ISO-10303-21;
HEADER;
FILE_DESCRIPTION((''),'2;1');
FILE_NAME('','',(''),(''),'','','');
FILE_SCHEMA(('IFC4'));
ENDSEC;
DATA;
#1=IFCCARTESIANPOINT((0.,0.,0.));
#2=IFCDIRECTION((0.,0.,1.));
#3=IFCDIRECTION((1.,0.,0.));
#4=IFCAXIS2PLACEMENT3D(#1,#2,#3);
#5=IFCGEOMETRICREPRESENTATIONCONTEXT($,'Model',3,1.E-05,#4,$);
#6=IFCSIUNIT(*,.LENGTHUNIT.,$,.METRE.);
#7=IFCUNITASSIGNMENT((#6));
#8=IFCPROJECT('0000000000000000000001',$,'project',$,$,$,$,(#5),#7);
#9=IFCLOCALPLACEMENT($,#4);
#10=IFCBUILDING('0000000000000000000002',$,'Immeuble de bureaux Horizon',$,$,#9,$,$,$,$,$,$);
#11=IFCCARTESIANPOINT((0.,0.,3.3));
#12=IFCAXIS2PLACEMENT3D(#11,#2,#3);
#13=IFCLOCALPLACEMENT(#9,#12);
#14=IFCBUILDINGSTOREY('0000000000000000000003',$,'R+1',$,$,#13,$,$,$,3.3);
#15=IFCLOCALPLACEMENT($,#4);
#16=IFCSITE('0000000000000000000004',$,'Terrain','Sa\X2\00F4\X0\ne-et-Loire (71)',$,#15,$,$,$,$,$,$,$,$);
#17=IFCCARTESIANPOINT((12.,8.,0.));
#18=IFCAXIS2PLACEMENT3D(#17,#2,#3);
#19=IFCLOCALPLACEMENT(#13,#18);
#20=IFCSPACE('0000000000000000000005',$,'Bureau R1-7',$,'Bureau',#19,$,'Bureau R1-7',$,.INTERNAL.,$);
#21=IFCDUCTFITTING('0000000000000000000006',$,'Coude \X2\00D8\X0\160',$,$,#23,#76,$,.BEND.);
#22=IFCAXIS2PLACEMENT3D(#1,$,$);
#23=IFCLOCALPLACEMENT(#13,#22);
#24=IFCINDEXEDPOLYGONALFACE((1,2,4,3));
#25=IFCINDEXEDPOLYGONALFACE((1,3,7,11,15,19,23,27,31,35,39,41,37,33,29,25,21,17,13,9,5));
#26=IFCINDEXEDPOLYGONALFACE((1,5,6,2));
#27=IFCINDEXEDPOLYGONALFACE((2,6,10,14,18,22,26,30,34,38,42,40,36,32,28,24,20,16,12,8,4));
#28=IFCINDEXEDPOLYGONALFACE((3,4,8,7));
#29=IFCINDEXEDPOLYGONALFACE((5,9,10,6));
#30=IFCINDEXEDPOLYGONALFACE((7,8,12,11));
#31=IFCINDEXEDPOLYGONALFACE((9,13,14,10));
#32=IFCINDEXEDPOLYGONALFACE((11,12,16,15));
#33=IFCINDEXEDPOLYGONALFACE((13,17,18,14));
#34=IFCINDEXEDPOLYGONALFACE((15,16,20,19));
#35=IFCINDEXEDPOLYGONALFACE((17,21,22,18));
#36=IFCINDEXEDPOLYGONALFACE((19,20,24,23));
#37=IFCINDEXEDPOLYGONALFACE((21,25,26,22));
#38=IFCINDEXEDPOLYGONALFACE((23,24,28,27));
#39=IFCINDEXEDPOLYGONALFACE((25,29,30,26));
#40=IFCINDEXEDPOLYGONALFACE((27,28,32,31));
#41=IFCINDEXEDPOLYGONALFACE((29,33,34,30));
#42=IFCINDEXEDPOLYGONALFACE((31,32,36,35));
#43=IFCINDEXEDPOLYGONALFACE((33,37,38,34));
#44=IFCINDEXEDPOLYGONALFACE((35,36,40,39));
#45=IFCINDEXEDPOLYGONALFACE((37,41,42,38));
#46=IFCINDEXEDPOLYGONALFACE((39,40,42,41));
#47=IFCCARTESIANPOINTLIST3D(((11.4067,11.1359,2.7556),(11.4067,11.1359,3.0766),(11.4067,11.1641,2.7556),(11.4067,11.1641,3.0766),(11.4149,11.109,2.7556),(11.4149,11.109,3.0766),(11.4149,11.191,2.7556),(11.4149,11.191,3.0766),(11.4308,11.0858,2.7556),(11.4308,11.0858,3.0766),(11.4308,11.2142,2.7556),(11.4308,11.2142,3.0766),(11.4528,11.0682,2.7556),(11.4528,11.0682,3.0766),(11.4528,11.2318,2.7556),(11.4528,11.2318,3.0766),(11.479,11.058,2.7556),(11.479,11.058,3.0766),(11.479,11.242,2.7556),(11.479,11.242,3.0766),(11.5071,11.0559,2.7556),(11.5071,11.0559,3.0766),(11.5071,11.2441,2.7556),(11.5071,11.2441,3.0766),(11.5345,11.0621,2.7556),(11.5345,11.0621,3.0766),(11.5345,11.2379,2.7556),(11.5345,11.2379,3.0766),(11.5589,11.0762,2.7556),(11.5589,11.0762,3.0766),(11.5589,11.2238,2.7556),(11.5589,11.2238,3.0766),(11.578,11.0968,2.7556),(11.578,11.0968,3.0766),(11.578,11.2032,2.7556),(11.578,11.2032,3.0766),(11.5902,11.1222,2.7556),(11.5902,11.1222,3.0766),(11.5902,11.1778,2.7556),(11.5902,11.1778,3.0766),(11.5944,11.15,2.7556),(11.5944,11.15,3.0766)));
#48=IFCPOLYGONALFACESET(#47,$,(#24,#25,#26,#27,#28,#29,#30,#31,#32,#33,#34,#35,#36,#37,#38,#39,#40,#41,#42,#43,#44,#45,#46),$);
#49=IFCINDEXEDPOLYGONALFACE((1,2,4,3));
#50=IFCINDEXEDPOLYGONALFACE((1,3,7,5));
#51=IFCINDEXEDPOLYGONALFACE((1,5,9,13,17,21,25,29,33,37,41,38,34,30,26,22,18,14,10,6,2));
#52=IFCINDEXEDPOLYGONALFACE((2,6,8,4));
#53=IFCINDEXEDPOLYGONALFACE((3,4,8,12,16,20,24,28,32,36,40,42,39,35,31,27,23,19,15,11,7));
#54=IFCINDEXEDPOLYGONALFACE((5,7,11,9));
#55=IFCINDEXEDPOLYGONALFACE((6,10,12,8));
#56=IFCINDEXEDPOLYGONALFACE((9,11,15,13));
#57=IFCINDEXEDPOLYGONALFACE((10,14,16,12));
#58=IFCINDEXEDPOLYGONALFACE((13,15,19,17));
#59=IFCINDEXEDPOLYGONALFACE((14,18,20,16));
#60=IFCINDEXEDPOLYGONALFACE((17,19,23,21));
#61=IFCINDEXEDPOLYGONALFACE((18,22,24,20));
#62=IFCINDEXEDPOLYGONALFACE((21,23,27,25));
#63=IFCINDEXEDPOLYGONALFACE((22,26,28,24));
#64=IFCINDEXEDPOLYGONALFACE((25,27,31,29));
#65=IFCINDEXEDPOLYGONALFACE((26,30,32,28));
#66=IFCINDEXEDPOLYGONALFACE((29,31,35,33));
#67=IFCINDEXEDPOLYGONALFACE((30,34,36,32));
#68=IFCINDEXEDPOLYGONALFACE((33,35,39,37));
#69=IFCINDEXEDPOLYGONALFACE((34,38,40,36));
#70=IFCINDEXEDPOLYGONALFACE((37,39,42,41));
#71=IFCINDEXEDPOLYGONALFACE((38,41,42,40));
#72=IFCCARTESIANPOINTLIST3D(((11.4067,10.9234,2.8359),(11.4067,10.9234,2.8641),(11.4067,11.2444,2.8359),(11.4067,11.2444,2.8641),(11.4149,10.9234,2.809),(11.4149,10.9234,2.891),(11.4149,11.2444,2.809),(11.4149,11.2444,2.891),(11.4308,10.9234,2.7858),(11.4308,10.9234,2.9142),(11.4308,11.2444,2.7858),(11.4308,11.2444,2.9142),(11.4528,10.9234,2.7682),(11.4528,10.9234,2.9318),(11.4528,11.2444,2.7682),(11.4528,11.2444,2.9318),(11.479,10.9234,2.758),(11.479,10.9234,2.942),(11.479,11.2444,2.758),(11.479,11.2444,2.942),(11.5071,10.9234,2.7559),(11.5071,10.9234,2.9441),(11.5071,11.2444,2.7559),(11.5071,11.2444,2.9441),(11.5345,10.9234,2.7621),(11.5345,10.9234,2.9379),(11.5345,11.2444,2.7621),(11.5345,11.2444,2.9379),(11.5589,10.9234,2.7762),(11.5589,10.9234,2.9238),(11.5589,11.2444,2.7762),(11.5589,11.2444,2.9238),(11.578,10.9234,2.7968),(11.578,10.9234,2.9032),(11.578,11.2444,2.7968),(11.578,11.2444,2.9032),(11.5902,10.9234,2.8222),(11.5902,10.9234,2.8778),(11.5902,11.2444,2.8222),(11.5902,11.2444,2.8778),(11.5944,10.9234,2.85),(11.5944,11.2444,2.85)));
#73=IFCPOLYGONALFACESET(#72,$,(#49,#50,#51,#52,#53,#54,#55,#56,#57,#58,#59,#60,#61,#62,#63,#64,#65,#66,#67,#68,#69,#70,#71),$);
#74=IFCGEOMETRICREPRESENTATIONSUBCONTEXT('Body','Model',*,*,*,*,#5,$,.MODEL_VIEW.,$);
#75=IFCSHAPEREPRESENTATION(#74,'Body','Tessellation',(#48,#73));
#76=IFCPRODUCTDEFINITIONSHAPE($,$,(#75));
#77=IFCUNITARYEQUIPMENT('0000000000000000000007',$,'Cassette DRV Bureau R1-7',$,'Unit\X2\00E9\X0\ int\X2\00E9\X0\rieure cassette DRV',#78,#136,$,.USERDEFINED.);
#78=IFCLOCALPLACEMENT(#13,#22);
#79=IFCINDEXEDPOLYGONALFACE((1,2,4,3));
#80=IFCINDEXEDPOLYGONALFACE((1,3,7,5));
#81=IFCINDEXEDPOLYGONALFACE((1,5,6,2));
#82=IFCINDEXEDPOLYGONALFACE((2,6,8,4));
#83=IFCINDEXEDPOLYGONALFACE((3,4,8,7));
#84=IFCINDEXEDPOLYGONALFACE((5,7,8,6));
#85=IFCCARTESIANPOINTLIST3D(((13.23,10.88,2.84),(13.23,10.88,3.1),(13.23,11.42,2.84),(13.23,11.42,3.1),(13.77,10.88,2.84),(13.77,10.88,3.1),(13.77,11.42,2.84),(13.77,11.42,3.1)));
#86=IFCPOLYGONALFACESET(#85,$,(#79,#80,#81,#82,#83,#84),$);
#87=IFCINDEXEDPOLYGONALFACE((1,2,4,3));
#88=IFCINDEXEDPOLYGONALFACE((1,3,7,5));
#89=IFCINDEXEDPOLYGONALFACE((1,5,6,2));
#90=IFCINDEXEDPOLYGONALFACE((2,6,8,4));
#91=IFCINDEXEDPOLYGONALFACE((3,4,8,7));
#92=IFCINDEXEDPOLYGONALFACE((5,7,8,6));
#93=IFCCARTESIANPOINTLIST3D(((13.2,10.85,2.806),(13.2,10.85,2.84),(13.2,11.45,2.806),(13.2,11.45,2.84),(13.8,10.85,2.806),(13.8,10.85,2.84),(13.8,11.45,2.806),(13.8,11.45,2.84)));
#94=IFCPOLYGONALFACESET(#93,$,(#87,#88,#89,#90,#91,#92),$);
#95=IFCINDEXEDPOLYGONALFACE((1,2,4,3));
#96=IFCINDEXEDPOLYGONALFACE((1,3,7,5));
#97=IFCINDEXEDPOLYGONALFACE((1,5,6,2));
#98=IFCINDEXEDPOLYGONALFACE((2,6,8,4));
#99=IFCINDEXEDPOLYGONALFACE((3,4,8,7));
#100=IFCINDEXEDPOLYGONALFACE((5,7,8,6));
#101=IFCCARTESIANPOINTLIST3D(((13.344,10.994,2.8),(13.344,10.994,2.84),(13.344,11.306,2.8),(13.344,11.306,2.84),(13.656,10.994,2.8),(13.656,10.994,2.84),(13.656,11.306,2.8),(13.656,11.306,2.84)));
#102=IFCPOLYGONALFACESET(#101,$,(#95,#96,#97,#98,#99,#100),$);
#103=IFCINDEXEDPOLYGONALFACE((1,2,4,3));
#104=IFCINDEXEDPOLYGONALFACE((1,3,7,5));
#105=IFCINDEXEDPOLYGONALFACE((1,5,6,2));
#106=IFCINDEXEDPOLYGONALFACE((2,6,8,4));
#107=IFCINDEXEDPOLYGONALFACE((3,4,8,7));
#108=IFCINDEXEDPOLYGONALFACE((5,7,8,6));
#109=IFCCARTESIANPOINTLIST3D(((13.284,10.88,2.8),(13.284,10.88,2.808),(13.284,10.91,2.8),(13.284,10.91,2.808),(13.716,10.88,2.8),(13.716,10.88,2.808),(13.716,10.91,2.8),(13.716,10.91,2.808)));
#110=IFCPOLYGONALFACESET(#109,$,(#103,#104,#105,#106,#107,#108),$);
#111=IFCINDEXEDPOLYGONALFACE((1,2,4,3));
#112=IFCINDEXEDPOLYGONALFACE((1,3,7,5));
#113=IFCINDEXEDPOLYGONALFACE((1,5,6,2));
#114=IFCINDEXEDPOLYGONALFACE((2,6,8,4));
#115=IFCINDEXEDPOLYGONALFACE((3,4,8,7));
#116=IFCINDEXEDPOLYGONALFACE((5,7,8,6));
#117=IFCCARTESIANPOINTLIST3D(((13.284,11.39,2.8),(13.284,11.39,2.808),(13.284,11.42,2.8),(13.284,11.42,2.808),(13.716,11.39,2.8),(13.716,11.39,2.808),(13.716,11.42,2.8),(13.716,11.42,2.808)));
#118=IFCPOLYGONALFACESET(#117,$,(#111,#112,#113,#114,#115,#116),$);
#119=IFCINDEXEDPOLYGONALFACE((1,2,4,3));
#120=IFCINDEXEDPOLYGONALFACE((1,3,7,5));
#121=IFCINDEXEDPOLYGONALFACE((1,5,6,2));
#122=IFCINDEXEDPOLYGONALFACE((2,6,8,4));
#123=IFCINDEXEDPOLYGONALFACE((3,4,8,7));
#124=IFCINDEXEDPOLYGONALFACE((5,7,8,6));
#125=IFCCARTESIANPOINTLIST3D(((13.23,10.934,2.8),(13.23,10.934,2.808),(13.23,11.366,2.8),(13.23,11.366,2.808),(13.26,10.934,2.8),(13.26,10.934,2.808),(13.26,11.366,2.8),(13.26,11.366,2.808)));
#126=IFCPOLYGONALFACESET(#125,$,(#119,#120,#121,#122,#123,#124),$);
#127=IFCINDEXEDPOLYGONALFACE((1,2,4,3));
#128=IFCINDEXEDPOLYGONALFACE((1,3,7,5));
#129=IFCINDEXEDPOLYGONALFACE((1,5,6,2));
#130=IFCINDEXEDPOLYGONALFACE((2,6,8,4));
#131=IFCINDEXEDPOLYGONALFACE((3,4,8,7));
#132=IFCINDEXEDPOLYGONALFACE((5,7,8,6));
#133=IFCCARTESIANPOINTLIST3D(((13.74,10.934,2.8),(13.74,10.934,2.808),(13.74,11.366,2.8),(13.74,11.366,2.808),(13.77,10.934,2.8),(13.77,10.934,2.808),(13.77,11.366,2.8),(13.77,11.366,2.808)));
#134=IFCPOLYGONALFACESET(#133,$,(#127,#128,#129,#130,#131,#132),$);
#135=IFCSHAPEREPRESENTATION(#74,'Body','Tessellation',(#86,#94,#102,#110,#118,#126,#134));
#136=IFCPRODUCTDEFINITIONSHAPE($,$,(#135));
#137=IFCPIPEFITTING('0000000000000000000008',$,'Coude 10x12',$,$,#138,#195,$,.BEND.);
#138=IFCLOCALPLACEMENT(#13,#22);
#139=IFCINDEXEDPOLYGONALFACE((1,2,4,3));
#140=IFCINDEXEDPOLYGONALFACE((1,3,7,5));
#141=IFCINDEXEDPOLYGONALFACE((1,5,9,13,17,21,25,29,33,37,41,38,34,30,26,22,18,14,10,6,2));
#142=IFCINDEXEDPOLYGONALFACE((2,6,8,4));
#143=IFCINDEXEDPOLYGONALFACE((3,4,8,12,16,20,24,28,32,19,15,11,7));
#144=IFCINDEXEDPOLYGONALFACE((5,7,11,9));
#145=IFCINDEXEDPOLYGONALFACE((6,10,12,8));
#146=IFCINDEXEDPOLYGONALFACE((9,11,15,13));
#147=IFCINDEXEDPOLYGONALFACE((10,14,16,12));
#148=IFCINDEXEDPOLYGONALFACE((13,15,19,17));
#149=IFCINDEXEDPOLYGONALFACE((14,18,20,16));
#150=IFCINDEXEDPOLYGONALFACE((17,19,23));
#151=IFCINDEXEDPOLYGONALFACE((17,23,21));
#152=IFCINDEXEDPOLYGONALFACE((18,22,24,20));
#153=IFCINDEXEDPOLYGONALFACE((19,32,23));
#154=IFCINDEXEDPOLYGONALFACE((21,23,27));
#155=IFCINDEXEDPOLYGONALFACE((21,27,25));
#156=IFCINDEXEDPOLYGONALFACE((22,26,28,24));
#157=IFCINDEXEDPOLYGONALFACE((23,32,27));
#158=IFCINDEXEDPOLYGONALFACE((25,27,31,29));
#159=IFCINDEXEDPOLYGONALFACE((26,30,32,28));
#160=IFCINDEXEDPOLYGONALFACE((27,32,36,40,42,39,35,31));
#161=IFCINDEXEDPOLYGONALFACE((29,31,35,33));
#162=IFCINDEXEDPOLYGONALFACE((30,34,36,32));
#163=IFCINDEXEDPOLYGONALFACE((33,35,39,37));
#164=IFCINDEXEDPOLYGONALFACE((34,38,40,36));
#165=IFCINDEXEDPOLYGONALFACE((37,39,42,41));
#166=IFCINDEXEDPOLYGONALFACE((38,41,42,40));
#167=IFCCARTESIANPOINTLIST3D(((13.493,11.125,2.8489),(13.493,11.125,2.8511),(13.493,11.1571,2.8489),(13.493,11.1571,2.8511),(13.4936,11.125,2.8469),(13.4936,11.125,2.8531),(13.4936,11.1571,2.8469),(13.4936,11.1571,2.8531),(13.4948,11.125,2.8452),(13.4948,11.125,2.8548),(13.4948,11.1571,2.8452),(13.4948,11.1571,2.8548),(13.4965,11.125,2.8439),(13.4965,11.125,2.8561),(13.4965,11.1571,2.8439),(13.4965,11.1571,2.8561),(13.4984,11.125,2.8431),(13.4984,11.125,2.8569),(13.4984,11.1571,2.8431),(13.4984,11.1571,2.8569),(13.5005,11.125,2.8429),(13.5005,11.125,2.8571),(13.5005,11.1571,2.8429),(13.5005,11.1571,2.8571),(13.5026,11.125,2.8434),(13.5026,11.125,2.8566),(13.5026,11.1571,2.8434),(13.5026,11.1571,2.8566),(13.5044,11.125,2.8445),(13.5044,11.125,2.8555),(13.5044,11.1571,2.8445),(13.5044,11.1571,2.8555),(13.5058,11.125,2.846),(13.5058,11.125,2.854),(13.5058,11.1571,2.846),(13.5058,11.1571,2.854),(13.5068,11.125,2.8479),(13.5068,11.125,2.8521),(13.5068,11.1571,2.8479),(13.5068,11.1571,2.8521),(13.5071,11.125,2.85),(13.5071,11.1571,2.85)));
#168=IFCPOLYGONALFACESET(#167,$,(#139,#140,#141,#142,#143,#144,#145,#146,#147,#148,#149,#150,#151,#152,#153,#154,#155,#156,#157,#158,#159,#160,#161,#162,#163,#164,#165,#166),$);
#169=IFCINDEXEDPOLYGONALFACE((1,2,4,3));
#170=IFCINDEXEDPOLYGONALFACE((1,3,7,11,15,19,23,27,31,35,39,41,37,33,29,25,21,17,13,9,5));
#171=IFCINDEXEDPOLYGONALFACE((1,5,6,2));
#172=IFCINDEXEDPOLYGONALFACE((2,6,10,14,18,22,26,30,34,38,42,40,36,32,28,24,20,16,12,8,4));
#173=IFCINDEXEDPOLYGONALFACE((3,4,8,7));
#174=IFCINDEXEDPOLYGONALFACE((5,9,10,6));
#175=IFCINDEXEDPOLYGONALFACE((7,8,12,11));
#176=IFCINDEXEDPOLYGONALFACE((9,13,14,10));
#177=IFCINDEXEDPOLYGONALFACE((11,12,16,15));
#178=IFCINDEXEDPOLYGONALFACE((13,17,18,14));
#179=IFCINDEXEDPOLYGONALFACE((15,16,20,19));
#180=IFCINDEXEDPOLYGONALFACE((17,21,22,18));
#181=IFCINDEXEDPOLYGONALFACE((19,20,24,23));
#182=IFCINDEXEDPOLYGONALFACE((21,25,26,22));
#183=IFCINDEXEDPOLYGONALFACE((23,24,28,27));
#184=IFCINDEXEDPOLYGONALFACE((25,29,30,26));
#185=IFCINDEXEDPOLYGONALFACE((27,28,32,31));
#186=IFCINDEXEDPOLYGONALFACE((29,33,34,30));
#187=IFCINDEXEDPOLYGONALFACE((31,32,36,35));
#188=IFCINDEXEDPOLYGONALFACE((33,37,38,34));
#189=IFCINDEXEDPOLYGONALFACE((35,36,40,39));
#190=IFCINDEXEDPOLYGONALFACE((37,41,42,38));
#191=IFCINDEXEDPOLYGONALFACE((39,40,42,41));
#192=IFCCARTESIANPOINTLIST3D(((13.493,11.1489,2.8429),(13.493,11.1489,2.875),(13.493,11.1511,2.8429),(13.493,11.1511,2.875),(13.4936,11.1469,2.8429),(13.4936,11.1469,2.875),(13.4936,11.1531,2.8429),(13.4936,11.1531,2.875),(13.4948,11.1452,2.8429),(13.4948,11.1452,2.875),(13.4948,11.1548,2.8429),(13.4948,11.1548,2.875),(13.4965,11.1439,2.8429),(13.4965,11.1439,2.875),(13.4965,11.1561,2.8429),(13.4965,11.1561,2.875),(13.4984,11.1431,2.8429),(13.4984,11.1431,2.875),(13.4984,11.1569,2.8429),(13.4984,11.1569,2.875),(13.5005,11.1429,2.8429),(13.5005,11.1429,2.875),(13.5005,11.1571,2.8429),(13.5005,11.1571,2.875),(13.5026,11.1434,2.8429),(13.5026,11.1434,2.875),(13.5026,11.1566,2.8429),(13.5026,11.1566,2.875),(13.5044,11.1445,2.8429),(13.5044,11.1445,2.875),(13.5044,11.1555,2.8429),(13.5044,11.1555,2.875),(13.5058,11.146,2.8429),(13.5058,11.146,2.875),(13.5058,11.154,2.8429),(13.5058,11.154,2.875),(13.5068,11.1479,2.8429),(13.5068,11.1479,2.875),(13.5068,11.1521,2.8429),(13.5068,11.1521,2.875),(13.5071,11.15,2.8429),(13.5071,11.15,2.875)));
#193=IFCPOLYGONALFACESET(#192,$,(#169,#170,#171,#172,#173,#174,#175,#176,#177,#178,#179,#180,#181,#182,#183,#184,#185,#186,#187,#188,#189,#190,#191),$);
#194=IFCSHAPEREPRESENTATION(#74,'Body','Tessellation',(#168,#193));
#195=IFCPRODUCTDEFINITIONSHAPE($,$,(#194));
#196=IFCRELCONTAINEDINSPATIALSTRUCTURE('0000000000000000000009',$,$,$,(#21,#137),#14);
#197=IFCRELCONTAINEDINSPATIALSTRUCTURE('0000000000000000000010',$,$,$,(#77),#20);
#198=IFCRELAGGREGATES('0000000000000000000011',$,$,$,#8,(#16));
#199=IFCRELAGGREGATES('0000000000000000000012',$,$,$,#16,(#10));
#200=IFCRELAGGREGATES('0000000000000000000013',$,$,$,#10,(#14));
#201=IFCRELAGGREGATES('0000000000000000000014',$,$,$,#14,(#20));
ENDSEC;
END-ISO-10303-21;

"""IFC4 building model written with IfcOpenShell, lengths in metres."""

from ifc_helpers import new_model, si_unit, frame, frame_2d, origin_with_axes, place, context, subcontext, project, spatial, rectangle, circle, extrude, element, save


model = new_model("IFC4")

# Units and contexts
model_context = context("Model", 3, precision=1e-05, world=origin_with_axes())
body_context = subcontext(model_context, "Body", "Model", "MODEL_VIEW")
ifc_project = project(units=[si_unit("LENGTHUNIT", "METRE")], contexts=[model_context])

# Site, building, storey
site_placement = place(None, origin_with_axes())
site = spatial("IfcSite", under=ifc_project, at=site_placement, Name="Terrain", Description="Saône-et-Loire (71)")
building_placement = place(None, origin_with_axes())
building = spatial("IfcBuilding", under=site, at=building_placement, Name="Immeuble de bureaux Horizon")
storey_placement = place(building_placement, frame((0.0, 0.0, 3.3), z_axis=(0.0, 0.0, 1.0), x_axis=(1.0, 0.0, 0.0)))
storey = spatial("IfcBuildingStorey", under=building, at=storey_placement, Name="R+1", Elevation=3.3)

# Duct fitting
duct_fitting_placement = place(storey_placement, frame((11.5, 11.15, 2.85), z_axis=(0.0, 0.0, 1.0), x_axis=(1.0, 0.0, 0.0)))
element("IfcDuctFitting", 1, at=duct_fitting_placement, inside=storey, Name="Coude Ø160", PredefinedType="BEND", context=body_context, shape_type="SweptSolid", body=[
    extrude(circle(Radius=0.0944), frame((0.0, 0.0, -0.0944), z_axis=(0.0, 0.0, 1.0), x_axis=(1.0, 0.0, 0.0)), (0.0, 0.0, 1.0), 0.321),
    extrude(circle(Radius=0.0944), frame((0.0, 0.0944, 0.0), z_axis=(0.0, -1.0, 0.0), x_axis=(1.0, 0.0, 0.0)), (0.0, 0.0, 1.0), 0.321),
])

# Shared definitions
space_1_placement = place(storey_placement, frame((12.0, 8.0, 0.0), z_axis=(0.0, 0.0, 1.0), x_axis=(1.0, 0.0, 0.0)))
space_1 = spatial("IfcSpace", under=storey, at=space_1_placement, Name="Bureau R1-7", ObjectType="Bureau", LongName="Bureau R1-7", PredefinedType="INTERNAL")

# Unitary equipment
unitary_equipment_1_placement = place(space_1_placement, frame((1.2, 2.85, 2.8), z_axis=(0.0, 0.0, 1.0), x_axis=(1.0, 0.0, 0.0)))
element("IfcUnitaryEquipment", 2, at=unitary_equipment_1_placement, inside=space_1, Name="Cassette DRV Bureau R1-7", ObjectType="Unité intérieure cassette DRV", PredefinedType="USERDEFINED", context=body_context, shape_type="SweptSolid", body=[
    extrude(rectangle(XDim=0.54, YDim=0.54, at=frame_2d((0.27, 0.27))), frame((0.03, 0.03, 0.04), z_axis=(0.0, 0.0, 1.0), x_axis=(1.0, 0.0, 0.0)), (0.0, 0.0, 1.0), 0.26),
    extrude(rectangle(XDim=0.6, YDim=0.6, at=frame_2d((0.3, 0.3))), frame((0.0, 0.0, 0.006), z_axis=(0.0, 0.0, 1.0), x_axis=(1.0, 0.0, 0.0)), (0.0, 0.0, 1.0), 0.034),
    extrude(rectangle(XDim=0.312, YDim=0.312, at=frame_2d((0.156, 0.156))), frame((0.144, 0.144, 0.0), z_axis=(0.0, 0.0, 1.0), x_axis=(1.0, 0.0, 0.0)), (0.0, 0.0, 1.0), 0.04),
    extrude(rectangle(XDim=0.432, YDim=0.03, at=frame_2d((0.216, 0.015))), frame((0.084, 0.03, 0.0), z_axis=(0.0, 0.0, 1.0), x_axis=(1.0, 0.0, 0.0)), (0.0, 0.0, 1.0), 0.008),
    extrude(rectangle(XDim=0.432, YDim=0.03, at=frame_2d((0.216, 0.015))), frame((0.084, 0.54, 0.0), z_axis=(0.0, 0.0, 1.0), x_axis=(1.0, 0.0, 0.0)), (0.0, 0.0, 1.0), 0.008),
    extrude(rectangle(XDim=0.03, YDim=0.432, at=frame_2d((0.015, 0.216))), frame((0.03, 0.084, 0.0), z_axis=(0.0, 0.0, 1.0), x_axis=(1.0, 0.0, 0.0)), (0.0, 0.0, 1.0), 0.008),
    extrude(rectangle(XDim=0.03, YDim=0.432, at=frame_2d((0.015, 0.216))), frame((0.54, 0.084, 0.0), z_axis=(0.0, 0.0, 1.0), x_axis=(1.0, 0.0, 0.0)), (0.0, 0.0, 1.0), 0.008),
])

# Pipe fitting
pipe_fitting_1_placement = place(storey_placement, frame((13.5, 11.15, 2.85), z_axis=(0.0, 0.0, 1.0), x_axis=(1.0, 0.0, 0.0)))
element("IfcPipeFitting", 3, at=pipe_fitting_1_placement, inside=storey, Name="Coude 10x12", PredefinedType="BEND", context=body_context, shape_type="SweptSolid", body=[
    extrude(circle(Radius=0.0071), frame((0.0, 0.0071, 0.0), z_axis=(0.0, -1.0, 0.0), x_axis=(1.0, 0.0, 0.0)), (0.0, 0.0, 1.0), 0.0321),
    extrude(circle(Radius=0.0071), frame((0.0, 0.0, -0.0071), z_axis=(0.0, 0.0, 1.0), x_axis=(1.0, 0.0, 0.0)), (0.0, 0.0, 1.0), 0.0321),
])

save(model, "model.ifc")
